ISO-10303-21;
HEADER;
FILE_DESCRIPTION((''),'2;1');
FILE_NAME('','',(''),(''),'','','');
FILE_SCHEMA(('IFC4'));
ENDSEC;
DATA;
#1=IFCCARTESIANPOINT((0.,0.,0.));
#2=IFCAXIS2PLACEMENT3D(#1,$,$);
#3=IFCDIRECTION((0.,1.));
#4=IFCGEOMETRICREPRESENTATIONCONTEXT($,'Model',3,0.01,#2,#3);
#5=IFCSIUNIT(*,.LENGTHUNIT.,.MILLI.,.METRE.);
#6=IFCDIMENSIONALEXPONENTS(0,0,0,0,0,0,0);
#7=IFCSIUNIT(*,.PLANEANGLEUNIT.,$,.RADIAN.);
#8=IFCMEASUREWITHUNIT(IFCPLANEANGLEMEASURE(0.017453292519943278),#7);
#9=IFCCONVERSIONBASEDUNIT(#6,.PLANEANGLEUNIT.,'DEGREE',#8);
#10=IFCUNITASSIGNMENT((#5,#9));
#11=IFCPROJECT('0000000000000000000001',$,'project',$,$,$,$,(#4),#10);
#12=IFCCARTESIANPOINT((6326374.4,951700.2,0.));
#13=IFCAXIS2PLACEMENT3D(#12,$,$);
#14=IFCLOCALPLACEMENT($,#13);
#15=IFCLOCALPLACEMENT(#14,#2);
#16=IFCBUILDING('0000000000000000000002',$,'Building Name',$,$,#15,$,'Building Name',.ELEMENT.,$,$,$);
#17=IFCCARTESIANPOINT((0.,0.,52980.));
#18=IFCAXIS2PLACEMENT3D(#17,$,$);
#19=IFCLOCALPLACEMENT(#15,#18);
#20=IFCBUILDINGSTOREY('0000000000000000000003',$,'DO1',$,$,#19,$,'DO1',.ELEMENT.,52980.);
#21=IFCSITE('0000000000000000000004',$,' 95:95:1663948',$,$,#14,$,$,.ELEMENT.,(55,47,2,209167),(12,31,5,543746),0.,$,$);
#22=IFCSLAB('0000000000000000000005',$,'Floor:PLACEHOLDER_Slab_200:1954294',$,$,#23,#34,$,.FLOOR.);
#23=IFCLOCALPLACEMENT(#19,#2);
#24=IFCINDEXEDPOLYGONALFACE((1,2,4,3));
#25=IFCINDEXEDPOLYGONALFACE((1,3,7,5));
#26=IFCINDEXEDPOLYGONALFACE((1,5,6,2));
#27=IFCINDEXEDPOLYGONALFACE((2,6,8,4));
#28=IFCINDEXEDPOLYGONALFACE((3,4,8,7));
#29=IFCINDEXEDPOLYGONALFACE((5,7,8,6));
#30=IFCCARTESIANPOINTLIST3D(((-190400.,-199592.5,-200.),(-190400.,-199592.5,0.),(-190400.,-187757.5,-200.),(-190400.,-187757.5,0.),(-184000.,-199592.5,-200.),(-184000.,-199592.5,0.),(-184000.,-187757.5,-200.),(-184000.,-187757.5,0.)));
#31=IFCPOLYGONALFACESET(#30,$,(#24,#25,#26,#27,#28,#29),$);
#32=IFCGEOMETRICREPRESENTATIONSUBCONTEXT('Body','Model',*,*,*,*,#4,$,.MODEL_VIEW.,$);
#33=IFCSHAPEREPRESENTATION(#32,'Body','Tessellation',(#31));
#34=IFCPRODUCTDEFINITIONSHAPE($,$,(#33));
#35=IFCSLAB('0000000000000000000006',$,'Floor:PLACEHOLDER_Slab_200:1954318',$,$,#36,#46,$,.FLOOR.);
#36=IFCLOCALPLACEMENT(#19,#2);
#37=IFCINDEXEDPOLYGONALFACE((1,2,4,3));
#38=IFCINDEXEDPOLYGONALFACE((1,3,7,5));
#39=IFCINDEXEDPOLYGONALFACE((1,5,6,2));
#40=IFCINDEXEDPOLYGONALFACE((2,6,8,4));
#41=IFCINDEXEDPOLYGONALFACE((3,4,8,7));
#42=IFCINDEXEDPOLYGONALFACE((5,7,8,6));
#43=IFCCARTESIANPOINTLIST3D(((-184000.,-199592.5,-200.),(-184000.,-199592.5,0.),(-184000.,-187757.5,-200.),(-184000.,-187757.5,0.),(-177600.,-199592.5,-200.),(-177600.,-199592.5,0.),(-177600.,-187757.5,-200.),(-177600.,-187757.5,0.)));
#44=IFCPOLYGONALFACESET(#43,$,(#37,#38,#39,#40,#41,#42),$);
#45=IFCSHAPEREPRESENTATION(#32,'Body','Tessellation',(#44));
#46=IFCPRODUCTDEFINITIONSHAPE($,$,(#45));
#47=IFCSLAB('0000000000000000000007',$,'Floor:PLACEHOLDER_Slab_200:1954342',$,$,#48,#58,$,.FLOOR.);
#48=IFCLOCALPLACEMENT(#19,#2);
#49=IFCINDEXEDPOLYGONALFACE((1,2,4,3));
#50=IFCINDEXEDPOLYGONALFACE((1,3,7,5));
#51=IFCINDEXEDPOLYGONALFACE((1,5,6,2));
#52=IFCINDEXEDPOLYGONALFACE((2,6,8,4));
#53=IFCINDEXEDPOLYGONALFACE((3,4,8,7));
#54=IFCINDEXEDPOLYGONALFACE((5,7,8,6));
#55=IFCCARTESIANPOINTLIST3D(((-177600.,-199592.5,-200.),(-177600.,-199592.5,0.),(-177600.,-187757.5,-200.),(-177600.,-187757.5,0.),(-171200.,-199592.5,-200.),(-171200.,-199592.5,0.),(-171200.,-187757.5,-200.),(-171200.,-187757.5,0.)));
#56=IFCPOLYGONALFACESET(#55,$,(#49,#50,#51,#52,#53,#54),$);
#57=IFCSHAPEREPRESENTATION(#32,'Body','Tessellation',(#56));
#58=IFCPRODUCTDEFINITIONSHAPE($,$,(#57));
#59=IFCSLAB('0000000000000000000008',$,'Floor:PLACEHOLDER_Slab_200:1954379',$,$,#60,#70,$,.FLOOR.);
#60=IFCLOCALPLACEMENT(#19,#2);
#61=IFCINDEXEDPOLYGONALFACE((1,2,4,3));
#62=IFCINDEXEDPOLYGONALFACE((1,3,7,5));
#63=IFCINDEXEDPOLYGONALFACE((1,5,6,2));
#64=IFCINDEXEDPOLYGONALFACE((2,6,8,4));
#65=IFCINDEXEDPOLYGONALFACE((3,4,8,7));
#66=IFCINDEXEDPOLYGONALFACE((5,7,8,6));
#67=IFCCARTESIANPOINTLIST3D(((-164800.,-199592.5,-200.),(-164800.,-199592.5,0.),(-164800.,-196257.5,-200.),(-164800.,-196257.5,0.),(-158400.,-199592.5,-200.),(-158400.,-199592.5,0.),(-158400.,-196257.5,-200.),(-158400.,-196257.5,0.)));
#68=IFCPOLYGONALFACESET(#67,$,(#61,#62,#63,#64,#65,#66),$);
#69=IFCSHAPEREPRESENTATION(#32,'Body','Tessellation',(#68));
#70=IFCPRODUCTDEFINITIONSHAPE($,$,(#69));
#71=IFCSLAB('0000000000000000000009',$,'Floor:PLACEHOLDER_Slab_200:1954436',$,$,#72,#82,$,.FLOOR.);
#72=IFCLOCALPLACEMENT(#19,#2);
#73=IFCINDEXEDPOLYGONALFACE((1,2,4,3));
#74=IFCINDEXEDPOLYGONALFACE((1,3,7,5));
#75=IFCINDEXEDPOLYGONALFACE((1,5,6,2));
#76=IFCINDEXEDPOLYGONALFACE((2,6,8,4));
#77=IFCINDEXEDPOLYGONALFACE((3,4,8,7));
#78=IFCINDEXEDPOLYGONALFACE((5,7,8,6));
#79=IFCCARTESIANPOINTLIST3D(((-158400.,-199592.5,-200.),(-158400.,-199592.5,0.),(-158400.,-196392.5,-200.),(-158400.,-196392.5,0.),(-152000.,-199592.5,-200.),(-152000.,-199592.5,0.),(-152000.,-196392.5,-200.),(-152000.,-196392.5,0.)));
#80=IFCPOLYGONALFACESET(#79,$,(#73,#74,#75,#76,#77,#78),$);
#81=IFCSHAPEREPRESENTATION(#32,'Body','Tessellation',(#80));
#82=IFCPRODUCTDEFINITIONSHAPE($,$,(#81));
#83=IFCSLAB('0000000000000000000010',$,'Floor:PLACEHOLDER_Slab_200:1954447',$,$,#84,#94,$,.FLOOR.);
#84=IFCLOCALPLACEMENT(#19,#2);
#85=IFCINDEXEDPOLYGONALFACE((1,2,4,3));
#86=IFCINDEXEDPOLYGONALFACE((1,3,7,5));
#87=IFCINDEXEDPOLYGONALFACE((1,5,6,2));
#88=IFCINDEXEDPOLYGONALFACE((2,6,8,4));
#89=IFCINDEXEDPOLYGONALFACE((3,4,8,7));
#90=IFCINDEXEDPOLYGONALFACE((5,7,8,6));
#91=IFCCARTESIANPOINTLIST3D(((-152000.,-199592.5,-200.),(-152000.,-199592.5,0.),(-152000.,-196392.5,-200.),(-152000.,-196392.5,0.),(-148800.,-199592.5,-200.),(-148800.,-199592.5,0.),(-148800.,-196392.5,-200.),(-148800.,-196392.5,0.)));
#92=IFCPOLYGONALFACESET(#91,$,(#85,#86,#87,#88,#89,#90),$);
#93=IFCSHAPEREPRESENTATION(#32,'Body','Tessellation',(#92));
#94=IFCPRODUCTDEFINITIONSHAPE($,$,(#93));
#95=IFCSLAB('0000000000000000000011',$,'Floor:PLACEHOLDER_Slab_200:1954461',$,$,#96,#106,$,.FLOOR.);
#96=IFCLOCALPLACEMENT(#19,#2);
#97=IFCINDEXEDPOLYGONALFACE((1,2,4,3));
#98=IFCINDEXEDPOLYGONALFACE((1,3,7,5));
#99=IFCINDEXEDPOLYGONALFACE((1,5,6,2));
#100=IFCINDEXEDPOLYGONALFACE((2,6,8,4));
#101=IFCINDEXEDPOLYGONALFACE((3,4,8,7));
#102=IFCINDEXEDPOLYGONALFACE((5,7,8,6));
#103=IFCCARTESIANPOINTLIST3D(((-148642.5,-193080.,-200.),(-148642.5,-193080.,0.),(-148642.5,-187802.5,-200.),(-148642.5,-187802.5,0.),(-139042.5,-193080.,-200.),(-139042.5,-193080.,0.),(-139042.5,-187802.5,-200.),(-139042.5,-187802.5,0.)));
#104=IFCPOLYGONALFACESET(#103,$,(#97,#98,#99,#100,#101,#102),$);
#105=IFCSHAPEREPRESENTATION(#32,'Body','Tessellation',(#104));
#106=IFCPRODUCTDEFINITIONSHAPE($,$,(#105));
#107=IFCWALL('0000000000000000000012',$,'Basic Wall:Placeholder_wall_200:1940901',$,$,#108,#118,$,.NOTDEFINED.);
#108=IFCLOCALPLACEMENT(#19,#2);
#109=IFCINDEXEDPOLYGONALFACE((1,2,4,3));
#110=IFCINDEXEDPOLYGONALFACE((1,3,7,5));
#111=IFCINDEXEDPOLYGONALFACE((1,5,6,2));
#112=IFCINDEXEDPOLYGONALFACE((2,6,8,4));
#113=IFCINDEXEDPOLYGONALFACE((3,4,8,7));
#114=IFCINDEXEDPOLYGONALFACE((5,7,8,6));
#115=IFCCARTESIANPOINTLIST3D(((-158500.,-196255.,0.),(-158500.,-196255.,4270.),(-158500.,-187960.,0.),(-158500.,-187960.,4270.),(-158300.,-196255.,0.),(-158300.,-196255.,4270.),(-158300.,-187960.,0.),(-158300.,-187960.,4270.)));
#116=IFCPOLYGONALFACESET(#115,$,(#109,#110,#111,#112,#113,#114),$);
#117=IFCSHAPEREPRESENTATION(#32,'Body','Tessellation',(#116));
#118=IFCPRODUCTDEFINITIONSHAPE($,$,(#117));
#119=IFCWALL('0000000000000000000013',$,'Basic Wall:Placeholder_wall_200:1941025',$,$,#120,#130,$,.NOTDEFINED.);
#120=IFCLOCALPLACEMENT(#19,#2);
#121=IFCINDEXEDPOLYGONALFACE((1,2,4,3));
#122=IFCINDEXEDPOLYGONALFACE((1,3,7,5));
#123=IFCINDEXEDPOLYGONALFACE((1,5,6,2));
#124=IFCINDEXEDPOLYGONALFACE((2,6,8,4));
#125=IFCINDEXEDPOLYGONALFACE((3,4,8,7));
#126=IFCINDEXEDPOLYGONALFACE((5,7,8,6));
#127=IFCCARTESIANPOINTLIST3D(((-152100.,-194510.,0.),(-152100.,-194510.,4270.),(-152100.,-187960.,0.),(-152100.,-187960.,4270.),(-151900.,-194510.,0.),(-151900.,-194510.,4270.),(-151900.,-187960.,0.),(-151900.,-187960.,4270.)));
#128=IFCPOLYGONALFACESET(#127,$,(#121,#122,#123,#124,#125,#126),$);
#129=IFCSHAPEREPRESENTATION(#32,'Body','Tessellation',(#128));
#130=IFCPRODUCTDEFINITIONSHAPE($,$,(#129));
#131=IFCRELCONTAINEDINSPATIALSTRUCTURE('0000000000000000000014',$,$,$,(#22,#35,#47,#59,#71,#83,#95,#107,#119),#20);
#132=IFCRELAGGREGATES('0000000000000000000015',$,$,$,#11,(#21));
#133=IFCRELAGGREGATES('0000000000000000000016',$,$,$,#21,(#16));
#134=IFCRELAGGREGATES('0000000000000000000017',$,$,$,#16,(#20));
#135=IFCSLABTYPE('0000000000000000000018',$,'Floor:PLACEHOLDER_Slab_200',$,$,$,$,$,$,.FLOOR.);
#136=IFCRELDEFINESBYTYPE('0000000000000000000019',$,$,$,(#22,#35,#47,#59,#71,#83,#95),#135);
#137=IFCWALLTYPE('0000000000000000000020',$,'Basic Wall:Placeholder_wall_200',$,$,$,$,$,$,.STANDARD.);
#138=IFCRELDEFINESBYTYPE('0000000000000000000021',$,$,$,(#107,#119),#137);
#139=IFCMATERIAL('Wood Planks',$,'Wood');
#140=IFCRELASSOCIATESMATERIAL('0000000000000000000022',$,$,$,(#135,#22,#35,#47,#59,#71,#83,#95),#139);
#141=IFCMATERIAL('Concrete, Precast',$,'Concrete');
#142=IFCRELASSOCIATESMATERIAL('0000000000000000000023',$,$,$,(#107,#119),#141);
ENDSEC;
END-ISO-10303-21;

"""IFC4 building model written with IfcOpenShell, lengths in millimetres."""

from ifc_helpers import new_model, entity, si_unit, converted_unit, direction, frame, origin, place, context, subcontext, project, spatial, indexed_curve, outline, extrude, material, type_object, element, save


model = new_model("IFC4")

# Units and contexts
model_context = context("Model", 3, precision=0.01, world=origin(), true_north=direction((0.0, 1.0)))
body_context = subcontext(model_context, "Body", "Model", "MODEL_VIEW")
ifc_project = project(units=[si_unit("LENGTHUNIT", "METRE", prefix="MILLI"), converted_unit("PLANEANGLEUNIT", "DEGREE", entity("IfcPlaneAngleMeasure", 0.017453292519943278), si_unit("PLANEANGLEUNIT", "RADIAN"), dimensions=[0, 0, 0, 0, 0, 0, 0])], contexts=[model_context])

# Site, building, storey
site_placement = place(None, frame((6326374.4, 951700.2, 0.0)))
site = spatial("IfcSite", under=ifc_project, at=site_placement, Name=" 95:95:1663948", CompositionType="ELEMENT", RefLatitude=(55, 47, 2, 209167), RefLongitude=(12, 31, 5, 543746), RefElevation=0.0)
building_placement = place(site_placement, origin())
building = spatial("IfcBuilding", under=site, at=building_placement, Name="Building Name", LongName="Building Name", CompositionType="ELEMENT")
storey_placement = place(building_placement, frame((0.0, 0.0, 52980.0)))
storey = spatial("IfcBuildingStorey", under=building, at=storey_placement, Name="DO1", LongName="DO1", CompositionType="ELEMENT", Elevation=52980.0)

# Slabs
ifc_material_1 = material(Name="Wood Planks", Category="Wood")
slab_type_1 = type_object("IfcSlabType", Name="Floor:PLACEHOLDER_Slab_200", PredefinedType="FLOOR", material=ifc_material_1)
slab_1_placement = place(storey_placement, origin())
element("IfcSlab", 1, at=slab_1_placement, inside=storey, type_object=slab_type_1, material=ifc_material_1, Name="Floor:PLACEHOLDER_Slab_200:1954294", PredefinedType="FLOOR", context=body_context, shape_type="SweptSolid", body=[
    extrude(outline(indexed_curve([(-5917.5, -3200.0), (5917.5, -3200.0), (5917.5, 3200.0), (-5917.5, 3200.0), (-5917.5, -3200.0)], self_intersect=False)), frame((-187200.0, -193675.0, 0.0), z_axis=(0.0, 0.0, -1.0), x_axis=(0.0, 1.0, 0.0)), (0.0, 0.0, 1.0), 200.0),
])
slab_2_placement = place(storey_placement, origin())
element("IfcSlab", 2, at=slab_2_placement, inside=storey, type_object=slab_type_1, material=ifc_material_1, Name="Floor:PLACEHOLDER_Slab_200:1954318", PredefinedType="FLOOR", context=body_context, shape_type="SweptSolid", body=[
    extrude(outline(indexed_curve([(-5917.5, -3200.0), (5917.5, -3200.0), (5917.5, 3200.0), (-5917.5, 3200.0), (-5917.5, -3200.0)], self_intersect=False)), frame((-180800.0, -193675.0, 0.0), z_axis=(0.0, 0.0, -1.0), x_axis=(0.0, 1.0, 0.0)), (0.0, 0.0, 1.0), 200.0),
])
slab_3_placement = place(storey_placement, origin())
element("IfcSlab", 3, at=slab_3_placement, inside=storey, type_object=slab_type_1, material=ifc_material_1, Name="Floor:PLACEHOLDER_Slab_200:1954342", PredefinedType="FLOOR", context=body_context, shape_type="SweptSolid", body=[
    extrude(outline(indexed_curve([(-5917.5, -3200.0), (5917.5, -3200.0), (5917.5, 3200.0), (-5917.5, 3200.0), (-5917.5, -3200.0)], self_intersect=False)), frame((-174400.0, -193675.0, 0.0), z_axis=(0.0, 0.0, -1.0), x_axis=(0.0, 1.0, 0.0)), (0.0, 0.0, 1.0), 200.0),
])
slab_4_placement = place(storey_placement, origin())
element("IfcSlab", 4, at=slab_4_placement, inside=storey, type_object=slab_type_1, material=ifc_material_1, Name="Floor:PLACEHOLDER_Slab_200:1954379", PredefinedType="FLOOR", context=body_context, shape_type="SweptSolid", body=[
    extrude(outline(indexed_curve([(-1667.5, -3200.0), (1667.5, -3200.0), (1667.5, 3200.0), (-1667.5, 3200.0), (-1667.5, -3200.0)], self_intersect=False)), frame((-161600.0, -197925.0, 0.0), z_axis=(0.0, 0.0, -1.0), x_axis=(0.0, 1.0, 0.0)), (0.0, 0.0, 1.0), 200.0),
])
slab_5_placement = place(storey_placement, origin())
element("IfcSlab", 5, at=slab_5_placement, inside=storey, type_object=slab_type_1, material=ifc_material_1, Name="Floor:PLACEHOLDER_Slab_200:1954436", PredefinedType="FLOOR", context=body_context, shape_type="SweptSolid", body=[
    extrude(outline(indexed_curve([(-1600.0, -3200.0), (1600.0, -3200.0), (1600.0, 3200.0), (-1600.0, 3200.0), (-1600.0, -3200.0)], self_intersect=False)), frame((-155200.0, -197992.5, 0.0), z_axis=(0.0, 0.0, -1.0), x_axis=(0.0, 1.0, 0.0)), (0.0, 0.0, 1.0), 200.0),
])
slab_6_placement = place(storey_placement, origin())
element("IfcSlab", 6, at=slab_6_placement, inside=storey, type_object=slab_type_1, material=ifc_material_1, Name="Floor:PLACEHOLDER_Slab_200:1954447", PredefinedType="FLOOR", context=body_context, shape_type="SweptSolid", body=[
    extrude(outline(indexed_curve([(-1600.0, -1600.0), (1600.0, -1600.0), (1600.0, 1600.0), (-1600.0, 1600.0), (-1600.0, -1600.0)], self_intersect=False)), frame((-150400.0, -197992.5, 0.0), z_axis=(0.0, 0.0, -1.0), x_axis=(0.0, 1.0, 0.0)), (0.0, 0.0, 1.0), 200.0),
])
slab_7_placement = place(storey_placement, origin())
element("IfcSlab", 7, at=slab_7_placement, inside=storey, type_object=slab_type_1, material=ifc_material_1, Name="Floor:PLACEHOLDER_Slab_200:1954461", PredefinedType="FLOOR", context=body_context, shape_type="SweptSolid", body=[
    extrude(outline(indexed_curve([(-2638.8, -4800.0), (2638.8, -4800.0), (2638.8, 4800.0), (-2638.8, 4800.0), (-2638.8, -4800.0)], self_intersect=False)), frame((-143842.5, -190441.3, 0.0), z_axis=(0.0, 0.0, -1.0), x_axis=(0.0, 1.0, 0.0)), (0.0, 0.0, 1.0), 200.0),
])

# Walls
ifc_material_2 = material(Name="Concrete, Precast", Category="Concrete")
wall_type = type_object("IfcWallType", Name="Basic Wall:Placeholder_wall_200", PredefinedType="STANDARD")
wall_1_placement = place(storey_placement, frame((-158400.0, -187960.0, 0.0), z_axis=(0.0, 0.0, 1.0), x_axis=(0.0, -1.0, 0.0)))
element("IfcWall", 8, at=wall_1_placement, inside=storey, type_object=wall_type, material=ifc_material_2, Name="Basic Wall:Placeholder_wall_200:1940901", PredefinedType="NOTDEFINED", context=body_context, shape_type="SweptSolid", body=[
    extrude(outline(indexed_curve([(8295.0, 100.0), (0.0, 100.0), (0.0, -100.0), (8295.0, -100.0), (8295.0, 100.0)], self_intersect=False)), origin(), (0.0, 0.0, 1.0), 4270.0),
])
wall_2_placement = place(storey_placement, frame((-152000.0, -194510.0, 0.0), z_axis=(0.0, 0.0, 1.0), x_axis=(0.0, 1.0, 0.0)))
element("IfcWall", 9, at=wall_2_placement, inside=storey, type_object=wall_type, material=ifc_material_2, Name="Basic Wall:Placeholder_wall_200:1941025", PredefinedType="NOTDEFINED", context=body_context, shape_type="SweptSolid", body=[
    extrude(outline(indexed_curve([(6550.0, 100.0), (0.0, 100.0), (0.0, -100.0), (6550.0, -100.0), (6550.0, 100.0)], self_intersect=False)), origin(), (0.0, 0.0, 1.0), 4270.0),
])

save(model, "model.ifc")
